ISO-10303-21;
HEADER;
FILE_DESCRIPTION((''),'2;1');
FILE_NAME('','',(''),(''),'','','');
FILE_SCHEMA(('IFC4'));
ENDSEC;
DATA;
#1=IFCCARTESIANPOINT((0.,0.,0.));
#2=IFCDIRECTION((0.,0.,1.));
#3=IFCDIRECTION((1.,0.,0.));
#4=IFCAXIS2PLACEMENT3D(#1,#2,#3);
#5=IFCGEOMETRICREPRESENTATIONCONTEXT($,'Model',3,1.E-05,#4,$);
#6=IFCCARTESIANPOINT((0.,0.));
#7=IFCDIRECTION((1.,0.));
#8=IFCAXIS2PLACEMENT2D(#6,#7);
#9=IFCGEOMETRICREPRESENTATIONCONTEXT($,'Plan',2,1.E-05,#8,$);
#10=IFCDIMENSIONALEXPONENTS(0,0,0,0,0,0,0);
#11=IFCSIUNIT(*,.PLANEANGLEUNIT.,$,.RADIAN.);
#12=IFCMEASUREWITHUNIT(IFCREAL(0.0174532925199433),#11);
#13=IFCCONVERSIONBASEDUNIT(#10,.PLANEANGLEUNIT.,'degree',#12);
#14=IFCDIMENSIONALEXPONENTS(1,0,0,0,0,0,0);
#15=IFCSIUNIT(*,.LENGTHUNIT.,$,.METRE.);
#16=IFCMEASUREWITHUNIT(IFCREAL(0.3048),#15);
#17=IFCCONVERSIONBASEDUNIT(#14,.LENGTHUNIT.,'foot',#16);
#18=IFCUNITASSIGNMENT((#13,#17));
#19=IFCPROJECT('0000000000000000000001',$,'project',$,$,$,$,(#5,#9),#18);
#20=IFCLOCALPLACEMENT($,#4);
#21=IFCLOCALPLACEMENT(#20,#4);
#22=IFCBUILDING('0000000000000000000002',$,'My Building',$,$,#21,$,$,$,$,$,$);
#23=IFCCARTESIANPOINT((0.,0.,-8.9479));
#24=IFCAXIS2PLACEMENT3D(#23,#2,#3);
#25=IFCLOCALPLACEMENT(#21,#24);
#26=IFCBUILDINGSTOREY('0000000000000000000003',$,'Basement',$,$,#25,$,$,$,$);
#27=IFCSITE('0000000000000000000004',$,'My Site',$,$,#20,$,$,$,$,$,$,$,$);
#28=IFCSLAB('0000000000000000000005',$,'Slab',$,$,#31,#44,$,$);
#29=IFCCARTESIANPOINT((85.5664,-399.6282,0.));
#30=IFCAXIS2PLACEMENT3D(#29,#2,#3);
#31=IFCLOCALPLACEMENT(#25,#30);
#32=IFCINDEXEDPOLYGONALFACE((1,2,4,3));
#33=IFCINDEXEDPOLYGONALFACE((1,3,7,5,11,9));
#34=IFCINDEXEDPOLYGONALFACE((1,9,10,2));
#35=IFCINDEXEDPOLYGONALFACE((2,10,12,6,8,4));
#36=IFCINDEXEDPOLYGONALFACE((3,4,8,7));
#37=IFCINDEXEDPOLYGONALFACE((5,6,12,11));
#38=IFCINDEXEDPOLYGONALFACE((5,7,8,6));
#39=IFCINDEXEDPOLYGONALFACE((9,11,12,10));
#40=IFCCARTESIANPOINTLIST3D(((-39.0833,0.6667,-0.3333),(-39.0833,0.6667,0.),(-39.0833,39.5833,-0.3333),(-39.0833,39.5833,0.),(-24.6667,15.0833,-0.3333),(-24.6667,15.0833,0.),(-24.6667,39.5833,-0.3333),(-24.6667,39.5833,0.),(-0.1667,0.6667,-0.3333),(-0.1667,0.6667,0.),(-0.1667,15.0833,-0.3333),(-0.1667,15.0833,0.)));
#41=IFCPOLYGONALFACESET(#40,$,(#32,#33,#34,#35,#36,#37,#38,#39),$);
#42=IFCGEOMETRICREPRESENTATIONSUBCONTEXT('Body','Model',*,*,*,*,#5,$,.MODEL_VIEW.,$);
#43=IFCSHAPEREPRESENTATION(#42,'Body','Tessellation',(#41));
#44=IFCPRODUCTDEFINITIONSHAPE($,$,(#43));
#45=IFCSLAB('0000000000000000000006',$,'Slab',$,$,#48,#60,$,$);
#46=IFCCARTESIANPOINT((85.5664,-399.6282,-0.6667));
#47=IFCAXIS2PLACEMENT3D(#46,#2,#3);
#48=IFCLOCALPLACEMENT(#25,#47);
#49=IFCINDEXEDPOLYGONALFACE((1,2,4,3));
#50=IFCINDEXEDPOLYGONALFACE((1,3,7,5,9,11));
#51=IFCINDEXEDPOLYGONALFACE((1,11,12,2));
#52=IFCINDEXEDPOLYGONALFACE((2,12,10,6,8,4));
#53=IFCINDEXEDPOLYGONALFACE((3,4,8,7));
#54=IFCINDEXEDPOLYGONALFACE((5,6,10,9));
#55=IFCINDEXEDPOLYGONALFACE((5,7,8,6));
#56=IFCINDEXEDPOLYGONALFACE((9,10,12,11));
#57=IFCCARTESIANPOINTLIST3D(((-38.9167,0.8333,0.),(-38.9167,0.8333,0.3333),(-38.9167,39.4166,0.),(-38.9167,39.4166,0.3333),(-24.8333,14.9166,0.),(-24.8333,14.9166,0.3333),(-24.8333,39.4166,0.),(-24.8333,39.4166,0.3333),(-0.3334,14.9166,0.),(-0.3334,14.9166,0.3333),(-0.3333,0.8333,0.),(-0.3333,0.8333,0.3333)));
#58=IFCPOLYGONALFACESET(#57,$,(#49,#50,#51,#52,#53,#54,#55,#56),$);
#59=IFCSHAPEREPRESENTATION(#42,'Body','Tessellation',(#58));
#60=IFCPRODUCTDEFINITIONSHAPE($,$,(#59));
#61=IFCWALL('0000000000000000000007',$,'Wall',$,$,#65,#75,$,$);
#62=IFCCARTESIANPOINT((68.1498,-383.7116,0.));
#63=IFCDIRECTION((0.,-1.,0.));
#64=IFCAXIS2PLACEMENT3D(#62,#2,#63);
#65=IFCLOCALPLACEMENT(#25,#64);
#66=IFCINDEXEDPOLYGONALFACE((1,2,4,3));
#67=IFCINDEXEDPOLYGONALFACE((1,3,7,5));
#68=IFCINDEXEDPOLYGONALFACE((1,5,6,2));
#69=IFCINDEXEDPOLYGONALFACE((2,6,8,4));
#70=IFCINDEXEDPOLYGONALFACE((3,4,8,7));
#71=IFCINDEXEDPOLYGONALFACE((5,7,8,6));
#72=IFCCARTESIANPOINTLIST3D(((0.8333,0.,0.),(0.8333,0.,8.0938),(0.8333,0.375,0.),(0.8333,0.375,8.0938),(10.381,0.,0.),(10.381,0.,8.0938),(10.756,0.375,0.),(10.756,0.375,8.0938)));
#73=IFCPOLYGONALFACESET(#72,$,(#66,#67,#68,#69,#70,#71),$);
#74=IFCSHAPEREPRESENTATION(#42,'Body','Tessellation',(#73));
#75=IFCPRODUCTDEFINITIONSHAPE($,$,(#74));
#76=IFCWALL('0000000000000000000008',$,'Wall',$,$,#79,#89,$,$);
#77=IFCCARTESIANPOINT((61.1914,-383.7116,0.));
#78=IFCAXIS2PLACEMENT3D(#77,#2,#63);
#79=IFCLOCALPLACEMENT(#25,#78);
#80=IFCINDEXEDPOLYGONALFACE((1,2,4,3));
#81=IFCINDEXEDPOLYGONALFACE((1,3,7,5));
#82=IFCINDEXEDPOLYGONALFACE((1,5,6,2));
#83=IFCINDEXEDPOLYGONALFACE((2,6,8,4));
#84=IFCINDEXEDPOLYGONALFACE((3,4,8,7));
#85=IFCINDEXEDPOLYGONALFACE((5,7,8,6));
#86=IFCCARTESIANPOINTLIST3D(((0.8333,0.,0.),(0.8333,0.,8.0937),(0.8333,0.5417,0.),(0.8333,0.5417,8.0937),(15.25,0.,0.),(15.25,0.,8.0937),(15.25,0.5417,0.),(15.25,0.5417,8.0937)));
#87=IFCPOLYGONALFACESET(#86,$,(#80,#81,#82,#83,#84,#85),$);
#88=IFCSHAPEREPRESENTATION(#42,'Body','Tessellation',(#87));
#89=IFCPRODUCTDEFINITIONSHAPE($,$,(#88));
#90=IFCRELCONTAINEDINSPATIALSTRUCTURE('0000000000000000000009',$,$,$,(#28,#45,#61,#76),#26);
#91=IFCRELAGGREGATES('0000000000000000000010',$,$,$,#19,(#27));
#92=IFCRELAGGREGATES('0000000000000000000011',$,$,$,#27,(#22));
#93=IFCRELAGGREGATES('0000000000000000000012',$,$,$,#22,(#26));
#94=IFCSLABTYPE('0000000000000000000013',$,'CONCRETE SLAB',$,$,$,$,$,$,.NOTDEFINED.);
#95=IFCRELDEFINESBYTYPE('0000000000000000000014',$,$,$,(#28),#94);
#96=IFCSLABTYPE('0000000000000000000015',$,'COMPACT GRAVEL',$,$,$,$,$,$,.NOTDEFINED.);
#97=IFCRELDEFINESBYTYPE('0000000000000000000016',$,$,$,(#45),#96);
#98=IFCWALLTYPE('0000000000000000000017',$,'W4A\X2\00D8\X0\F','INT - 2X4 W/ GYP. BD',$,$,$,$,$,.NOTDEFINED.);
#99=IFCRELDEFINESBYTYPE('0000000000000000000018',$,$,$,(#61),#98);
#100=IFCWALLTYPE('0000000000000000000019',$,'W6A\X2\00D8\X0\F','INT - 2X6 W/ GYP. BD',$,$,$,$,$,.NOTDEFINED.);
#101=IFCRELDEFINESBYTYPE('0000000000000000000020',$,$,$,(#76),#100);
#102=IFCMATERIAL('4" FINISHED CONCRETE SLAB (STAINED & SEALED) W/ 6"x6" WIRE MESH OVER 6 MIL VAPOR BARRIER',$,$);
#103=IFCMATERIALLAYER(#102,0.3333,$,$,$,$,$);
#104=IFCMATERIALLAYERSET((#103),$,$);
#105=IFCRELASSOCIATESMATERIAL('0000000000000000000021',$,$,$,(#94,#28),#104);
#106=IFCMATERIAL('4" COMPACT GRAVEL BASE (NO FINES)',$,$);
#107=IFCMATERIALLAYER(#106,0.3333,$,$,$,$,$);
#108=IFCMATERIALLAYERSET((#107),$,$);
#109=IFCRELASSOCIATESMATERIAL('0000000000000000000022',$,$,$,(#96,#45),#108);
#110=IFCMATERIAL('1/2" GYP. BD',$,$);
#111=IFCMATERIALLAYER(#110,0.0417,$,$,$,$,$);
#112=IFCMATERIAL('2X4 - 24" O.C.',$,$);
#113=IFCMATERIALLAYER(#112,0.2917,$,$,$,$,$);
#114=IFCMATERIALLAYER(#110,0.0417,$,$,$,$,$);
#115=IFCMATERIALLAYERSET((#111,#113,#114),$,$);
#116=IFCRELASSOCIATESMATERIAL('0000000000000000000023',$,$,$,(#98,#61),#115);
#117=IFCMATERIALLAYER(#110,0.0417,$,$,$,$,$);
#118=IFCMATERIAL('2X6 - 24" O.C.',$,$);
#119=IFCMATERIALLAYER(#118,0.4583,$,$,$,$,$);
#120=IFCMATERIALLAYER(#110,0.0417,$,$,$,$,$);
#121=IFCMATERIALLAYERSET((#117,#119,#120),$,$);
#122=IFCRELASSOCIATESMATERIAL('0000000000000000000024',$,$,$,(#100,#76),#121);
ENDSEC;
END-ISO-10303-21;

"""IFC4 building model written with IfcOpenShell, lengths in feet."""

from ifc_helpers import new_model, entity, si_unit, converted_unit, frame, origin_with_axes, origin_2d_with_axis, place, context, subcontext, project, spatial, line, indexed_curve, outline, extrude, material, layer, layer_set, layer_usage, type_object, element, save


model = new_model("IFC4")

# Units and contexts
model_context = context("Model", 3, precision=1e-05, world=origin_with_axes())
plan_context = context("Plan", 2, precision=1e-05, world=origin_2d_with_axis())
body_context = subcontext(model_context, "Body", "Model", "MODEL_VIEW")
ifc_project = project(units=[converted_unit("PLANEANGLEUNIT", "degree", entity("IfcReal", 0.0174532925199433), si_unit("PLANEANGLEUNIT", "RADIAN"), dimensions=[0, 0, 0, 0, 0, 0, 0]), converted_unit("LENGTHUNIT", "foot", entity("IfcReal", 0.3048), si_unit("LENGTHUNIT", "METRE"), dimensions=[1, 0, 0, 0, 0, 0, 0])], contexts=[model_context, plan_context])

# Site, building, storey
site_placement = place(None, origin_with_axes())
site = spatial("IfcSite", under=ifc_project, at=site_placement, Name="My Site")
building_placement = place(site_placement, origin_with_axes())
building = spatial("IfcBuilding", under=site, at=building_placement, Name="My Building")
storey_placement = place(building_placement, frame((0.0, 0.0, -8.9479), z_axis=(0.0, 0.0, 1.0), x_axis=(1.0, 0.0, 0.0)))
storey = spatial("IfcBuildingStorey", under=building, at=storey_placement, Name="Basement")

# Slabs
ifc_material_1 = material(Name="4\" FINISHED CONCRETE SLAB (STAINED & SEALED) W/ 6\"x6\" WIRE MESH OVER 6 MIL VAPOR BARRIER")
ifc_layer_1 = layer(ifc_material_1, 0.3333)
ifc_layer_set_1 = layer_set([ifc_layer_1])
ifc_layer_usage_1 = layer_usage(ifc_layer_set_1, "AXIS3", "POSITIVE", -0.3333)
slab_type_1 = type_object("IfcSlabType", Name="CONCRETE SLAB", PredefinedType="NOTDEFINED", material=ifc_layer_set_1)
slab_1_placement = place(storey_placement, frame((85.5664, -399.6282, 0.0), z_axis=(0.0, 0.0, 1.0), x_axis=(1.0, 0.0, 0.0)))
element("IfcSlab", 1, at=slab_1_placement, inside=storey, type_object=slab_type_1, material=ifc_layer_usage_1, Name="Slab", context=body_context, shape_type="SolidModel", body=[
    extrude(outline(indexed_curve([(-0.1667, 0.6667), (-39.0833, 0.6667), (-39.0833, 39.5833), (-24.6667, 39.5833), (-24.6667, 15.0833), (-0.1667, 15.0833), (-0.1667, 0.6667)])), frame((0.0, 0.0, -0.3333), z_axis=(0.0, 0.0, 1.0), x_axis=(1.0, 0.0, 0.0)), (0.0, 0.0, 1.0), 0.3333),
])
ifc_material_2 = material(Name="4\" COMPACT GRAVEL BASE (NO FINES)")
ifc_layer_2 = layer(ifc_material_2, 0.3333)
ifc_layer_set_2 = layer_set([ifc_layer_2])
ifc_layer_usage_2 = layer_usage(ifc_layer_set_2, "AXIS3", "POSITIVE", 0.0)
slab_type_2 = type_object("IfcSlabType", Name="COMPACT GRAVEL", PredefinedType="NOTDEFINED", material=ifc_layer_set_2)
slab_2_placement = place(storey_placement, frame((85.5664, -399.6282, -0.6667), z_axis=(0.0, 0.0, 1.0), x_axis=(1.0, 0.0, 0.0)))
element("IfcSlab", 2, at=slab_2_placement, inside=storey, type_object=slab_type_2, material=ifc_layer_usage_2, Name="Slab", context=body_context, shape_type="SweptSolid", body=[
    extrude(outline(indexed_curve([(-0.3333, 0.8333), (-38.9167, 0.8333), (-38.9167, 39.4166), (-24.8333, 39.4166), (-24.8333, 14.9166), (-0.3334, 14.9166), (-0.3333, 0.8333)])), None, (0.0, 0.0, 1.0), 0.3333),
])

# Wall
ifc_material_3 = material(Name="1/2\" GYP. BD")
ifc_layer_3 = layer(ifc_material_3, 0.0417)
ifc_material_4 = material(Name="2X4 - 24\" O.C.")
ifc_layer_4 = layer(ifc_material_4, 0.2917)
ifc_layer_5 = layer(ifc_material_3, 0.0417)
ifc_layer_set_3 = layer_set([ifc_layer_3, ifc_layer_4, ifc_layer_5])
ifc_layer_usage_3 = layer_usage(ifc_layer_set_3, "AXIS2", "POSITIVE", 0.0)
wall_type_1 = type_object("IfcWallType", Name="W4AØF", Description="INT - 2X4 W/ GYP. BD", PredefinedType="NOTDEFINED", material=ifc_layer_set_3)
wall_1_placement = place(storey_placement, frame((68.1498, -383.7116, 0.0), z_axis=(0.0, 0.0, 1.0), x_axis=(0.0, -1.0, 0.0)))
element("IfcWall", 3, at=wall_1_placement, inside=storey, type_object=wall_type_1, material=ifc_layer_usage_3, Name="Wall", context=body_context, shape_type="SweptSolid", body=[
    extrude(outline(indexed_curve([(0.8333, 0.0), (0.8333, 0.375), (10.756, 0.375), (10.381, 0.0)], segments=[line(1, 2, 3, 4, 1)])), origin_with_axes(), (0.0, 0.0, 1.0), 8.0938),
])

# Wall
ifc_layer_6 = layer(ifc_material_3, 0.0417)
ifc_material_5 = material(Name="2X6 - 24\" O.C.")
ifc_layer_7 = layer(ifc_material_5, 0.4583)
ifc_layer_8 = layer(ifc_material_3, 0.0417)
ifc_layer_set_4 = layer_set([ifc_layer_6, ifc_layer_7, ifc_layer_8])
ifc_layer_usage_4 = layer_usage(ifc_layer_set_4, "AXIS2", "POSITIVE", 0.0)
wall_type_2 = type_object("IfcWallType", Name="W6AØF", Description="INT - 2X6 W/ GYP. BD", PredefinedType="NOTDEFINED", material=ifc_layer_set_4)
wall_2_placement = place(storey_placement, frame((61.1914, -383.7116, 0.0), z_axis=(0.0, 0.0, 1.0), x_axis=(0.0, -1.0, 0.0)))
element("IfcWall", 4, at=wall_2_placement, inside=storey, type_object=wall_type_2, material=ifc_layer_usage_4, Name="Wall", context=body_context, shape_type="SweptSolid", body=[
    extrude(outline(indexed_curve([(0.8333, 0.0), (0.8333, 0.5417), (15.25, 0.5417), (15.25, 0.0)], segments=[line(1, 2, 3, 4, 1)])), origin_with_axes(), (0.0, 0.0, 1.0), 8.0937),
])

save(model, "model.ifc")
